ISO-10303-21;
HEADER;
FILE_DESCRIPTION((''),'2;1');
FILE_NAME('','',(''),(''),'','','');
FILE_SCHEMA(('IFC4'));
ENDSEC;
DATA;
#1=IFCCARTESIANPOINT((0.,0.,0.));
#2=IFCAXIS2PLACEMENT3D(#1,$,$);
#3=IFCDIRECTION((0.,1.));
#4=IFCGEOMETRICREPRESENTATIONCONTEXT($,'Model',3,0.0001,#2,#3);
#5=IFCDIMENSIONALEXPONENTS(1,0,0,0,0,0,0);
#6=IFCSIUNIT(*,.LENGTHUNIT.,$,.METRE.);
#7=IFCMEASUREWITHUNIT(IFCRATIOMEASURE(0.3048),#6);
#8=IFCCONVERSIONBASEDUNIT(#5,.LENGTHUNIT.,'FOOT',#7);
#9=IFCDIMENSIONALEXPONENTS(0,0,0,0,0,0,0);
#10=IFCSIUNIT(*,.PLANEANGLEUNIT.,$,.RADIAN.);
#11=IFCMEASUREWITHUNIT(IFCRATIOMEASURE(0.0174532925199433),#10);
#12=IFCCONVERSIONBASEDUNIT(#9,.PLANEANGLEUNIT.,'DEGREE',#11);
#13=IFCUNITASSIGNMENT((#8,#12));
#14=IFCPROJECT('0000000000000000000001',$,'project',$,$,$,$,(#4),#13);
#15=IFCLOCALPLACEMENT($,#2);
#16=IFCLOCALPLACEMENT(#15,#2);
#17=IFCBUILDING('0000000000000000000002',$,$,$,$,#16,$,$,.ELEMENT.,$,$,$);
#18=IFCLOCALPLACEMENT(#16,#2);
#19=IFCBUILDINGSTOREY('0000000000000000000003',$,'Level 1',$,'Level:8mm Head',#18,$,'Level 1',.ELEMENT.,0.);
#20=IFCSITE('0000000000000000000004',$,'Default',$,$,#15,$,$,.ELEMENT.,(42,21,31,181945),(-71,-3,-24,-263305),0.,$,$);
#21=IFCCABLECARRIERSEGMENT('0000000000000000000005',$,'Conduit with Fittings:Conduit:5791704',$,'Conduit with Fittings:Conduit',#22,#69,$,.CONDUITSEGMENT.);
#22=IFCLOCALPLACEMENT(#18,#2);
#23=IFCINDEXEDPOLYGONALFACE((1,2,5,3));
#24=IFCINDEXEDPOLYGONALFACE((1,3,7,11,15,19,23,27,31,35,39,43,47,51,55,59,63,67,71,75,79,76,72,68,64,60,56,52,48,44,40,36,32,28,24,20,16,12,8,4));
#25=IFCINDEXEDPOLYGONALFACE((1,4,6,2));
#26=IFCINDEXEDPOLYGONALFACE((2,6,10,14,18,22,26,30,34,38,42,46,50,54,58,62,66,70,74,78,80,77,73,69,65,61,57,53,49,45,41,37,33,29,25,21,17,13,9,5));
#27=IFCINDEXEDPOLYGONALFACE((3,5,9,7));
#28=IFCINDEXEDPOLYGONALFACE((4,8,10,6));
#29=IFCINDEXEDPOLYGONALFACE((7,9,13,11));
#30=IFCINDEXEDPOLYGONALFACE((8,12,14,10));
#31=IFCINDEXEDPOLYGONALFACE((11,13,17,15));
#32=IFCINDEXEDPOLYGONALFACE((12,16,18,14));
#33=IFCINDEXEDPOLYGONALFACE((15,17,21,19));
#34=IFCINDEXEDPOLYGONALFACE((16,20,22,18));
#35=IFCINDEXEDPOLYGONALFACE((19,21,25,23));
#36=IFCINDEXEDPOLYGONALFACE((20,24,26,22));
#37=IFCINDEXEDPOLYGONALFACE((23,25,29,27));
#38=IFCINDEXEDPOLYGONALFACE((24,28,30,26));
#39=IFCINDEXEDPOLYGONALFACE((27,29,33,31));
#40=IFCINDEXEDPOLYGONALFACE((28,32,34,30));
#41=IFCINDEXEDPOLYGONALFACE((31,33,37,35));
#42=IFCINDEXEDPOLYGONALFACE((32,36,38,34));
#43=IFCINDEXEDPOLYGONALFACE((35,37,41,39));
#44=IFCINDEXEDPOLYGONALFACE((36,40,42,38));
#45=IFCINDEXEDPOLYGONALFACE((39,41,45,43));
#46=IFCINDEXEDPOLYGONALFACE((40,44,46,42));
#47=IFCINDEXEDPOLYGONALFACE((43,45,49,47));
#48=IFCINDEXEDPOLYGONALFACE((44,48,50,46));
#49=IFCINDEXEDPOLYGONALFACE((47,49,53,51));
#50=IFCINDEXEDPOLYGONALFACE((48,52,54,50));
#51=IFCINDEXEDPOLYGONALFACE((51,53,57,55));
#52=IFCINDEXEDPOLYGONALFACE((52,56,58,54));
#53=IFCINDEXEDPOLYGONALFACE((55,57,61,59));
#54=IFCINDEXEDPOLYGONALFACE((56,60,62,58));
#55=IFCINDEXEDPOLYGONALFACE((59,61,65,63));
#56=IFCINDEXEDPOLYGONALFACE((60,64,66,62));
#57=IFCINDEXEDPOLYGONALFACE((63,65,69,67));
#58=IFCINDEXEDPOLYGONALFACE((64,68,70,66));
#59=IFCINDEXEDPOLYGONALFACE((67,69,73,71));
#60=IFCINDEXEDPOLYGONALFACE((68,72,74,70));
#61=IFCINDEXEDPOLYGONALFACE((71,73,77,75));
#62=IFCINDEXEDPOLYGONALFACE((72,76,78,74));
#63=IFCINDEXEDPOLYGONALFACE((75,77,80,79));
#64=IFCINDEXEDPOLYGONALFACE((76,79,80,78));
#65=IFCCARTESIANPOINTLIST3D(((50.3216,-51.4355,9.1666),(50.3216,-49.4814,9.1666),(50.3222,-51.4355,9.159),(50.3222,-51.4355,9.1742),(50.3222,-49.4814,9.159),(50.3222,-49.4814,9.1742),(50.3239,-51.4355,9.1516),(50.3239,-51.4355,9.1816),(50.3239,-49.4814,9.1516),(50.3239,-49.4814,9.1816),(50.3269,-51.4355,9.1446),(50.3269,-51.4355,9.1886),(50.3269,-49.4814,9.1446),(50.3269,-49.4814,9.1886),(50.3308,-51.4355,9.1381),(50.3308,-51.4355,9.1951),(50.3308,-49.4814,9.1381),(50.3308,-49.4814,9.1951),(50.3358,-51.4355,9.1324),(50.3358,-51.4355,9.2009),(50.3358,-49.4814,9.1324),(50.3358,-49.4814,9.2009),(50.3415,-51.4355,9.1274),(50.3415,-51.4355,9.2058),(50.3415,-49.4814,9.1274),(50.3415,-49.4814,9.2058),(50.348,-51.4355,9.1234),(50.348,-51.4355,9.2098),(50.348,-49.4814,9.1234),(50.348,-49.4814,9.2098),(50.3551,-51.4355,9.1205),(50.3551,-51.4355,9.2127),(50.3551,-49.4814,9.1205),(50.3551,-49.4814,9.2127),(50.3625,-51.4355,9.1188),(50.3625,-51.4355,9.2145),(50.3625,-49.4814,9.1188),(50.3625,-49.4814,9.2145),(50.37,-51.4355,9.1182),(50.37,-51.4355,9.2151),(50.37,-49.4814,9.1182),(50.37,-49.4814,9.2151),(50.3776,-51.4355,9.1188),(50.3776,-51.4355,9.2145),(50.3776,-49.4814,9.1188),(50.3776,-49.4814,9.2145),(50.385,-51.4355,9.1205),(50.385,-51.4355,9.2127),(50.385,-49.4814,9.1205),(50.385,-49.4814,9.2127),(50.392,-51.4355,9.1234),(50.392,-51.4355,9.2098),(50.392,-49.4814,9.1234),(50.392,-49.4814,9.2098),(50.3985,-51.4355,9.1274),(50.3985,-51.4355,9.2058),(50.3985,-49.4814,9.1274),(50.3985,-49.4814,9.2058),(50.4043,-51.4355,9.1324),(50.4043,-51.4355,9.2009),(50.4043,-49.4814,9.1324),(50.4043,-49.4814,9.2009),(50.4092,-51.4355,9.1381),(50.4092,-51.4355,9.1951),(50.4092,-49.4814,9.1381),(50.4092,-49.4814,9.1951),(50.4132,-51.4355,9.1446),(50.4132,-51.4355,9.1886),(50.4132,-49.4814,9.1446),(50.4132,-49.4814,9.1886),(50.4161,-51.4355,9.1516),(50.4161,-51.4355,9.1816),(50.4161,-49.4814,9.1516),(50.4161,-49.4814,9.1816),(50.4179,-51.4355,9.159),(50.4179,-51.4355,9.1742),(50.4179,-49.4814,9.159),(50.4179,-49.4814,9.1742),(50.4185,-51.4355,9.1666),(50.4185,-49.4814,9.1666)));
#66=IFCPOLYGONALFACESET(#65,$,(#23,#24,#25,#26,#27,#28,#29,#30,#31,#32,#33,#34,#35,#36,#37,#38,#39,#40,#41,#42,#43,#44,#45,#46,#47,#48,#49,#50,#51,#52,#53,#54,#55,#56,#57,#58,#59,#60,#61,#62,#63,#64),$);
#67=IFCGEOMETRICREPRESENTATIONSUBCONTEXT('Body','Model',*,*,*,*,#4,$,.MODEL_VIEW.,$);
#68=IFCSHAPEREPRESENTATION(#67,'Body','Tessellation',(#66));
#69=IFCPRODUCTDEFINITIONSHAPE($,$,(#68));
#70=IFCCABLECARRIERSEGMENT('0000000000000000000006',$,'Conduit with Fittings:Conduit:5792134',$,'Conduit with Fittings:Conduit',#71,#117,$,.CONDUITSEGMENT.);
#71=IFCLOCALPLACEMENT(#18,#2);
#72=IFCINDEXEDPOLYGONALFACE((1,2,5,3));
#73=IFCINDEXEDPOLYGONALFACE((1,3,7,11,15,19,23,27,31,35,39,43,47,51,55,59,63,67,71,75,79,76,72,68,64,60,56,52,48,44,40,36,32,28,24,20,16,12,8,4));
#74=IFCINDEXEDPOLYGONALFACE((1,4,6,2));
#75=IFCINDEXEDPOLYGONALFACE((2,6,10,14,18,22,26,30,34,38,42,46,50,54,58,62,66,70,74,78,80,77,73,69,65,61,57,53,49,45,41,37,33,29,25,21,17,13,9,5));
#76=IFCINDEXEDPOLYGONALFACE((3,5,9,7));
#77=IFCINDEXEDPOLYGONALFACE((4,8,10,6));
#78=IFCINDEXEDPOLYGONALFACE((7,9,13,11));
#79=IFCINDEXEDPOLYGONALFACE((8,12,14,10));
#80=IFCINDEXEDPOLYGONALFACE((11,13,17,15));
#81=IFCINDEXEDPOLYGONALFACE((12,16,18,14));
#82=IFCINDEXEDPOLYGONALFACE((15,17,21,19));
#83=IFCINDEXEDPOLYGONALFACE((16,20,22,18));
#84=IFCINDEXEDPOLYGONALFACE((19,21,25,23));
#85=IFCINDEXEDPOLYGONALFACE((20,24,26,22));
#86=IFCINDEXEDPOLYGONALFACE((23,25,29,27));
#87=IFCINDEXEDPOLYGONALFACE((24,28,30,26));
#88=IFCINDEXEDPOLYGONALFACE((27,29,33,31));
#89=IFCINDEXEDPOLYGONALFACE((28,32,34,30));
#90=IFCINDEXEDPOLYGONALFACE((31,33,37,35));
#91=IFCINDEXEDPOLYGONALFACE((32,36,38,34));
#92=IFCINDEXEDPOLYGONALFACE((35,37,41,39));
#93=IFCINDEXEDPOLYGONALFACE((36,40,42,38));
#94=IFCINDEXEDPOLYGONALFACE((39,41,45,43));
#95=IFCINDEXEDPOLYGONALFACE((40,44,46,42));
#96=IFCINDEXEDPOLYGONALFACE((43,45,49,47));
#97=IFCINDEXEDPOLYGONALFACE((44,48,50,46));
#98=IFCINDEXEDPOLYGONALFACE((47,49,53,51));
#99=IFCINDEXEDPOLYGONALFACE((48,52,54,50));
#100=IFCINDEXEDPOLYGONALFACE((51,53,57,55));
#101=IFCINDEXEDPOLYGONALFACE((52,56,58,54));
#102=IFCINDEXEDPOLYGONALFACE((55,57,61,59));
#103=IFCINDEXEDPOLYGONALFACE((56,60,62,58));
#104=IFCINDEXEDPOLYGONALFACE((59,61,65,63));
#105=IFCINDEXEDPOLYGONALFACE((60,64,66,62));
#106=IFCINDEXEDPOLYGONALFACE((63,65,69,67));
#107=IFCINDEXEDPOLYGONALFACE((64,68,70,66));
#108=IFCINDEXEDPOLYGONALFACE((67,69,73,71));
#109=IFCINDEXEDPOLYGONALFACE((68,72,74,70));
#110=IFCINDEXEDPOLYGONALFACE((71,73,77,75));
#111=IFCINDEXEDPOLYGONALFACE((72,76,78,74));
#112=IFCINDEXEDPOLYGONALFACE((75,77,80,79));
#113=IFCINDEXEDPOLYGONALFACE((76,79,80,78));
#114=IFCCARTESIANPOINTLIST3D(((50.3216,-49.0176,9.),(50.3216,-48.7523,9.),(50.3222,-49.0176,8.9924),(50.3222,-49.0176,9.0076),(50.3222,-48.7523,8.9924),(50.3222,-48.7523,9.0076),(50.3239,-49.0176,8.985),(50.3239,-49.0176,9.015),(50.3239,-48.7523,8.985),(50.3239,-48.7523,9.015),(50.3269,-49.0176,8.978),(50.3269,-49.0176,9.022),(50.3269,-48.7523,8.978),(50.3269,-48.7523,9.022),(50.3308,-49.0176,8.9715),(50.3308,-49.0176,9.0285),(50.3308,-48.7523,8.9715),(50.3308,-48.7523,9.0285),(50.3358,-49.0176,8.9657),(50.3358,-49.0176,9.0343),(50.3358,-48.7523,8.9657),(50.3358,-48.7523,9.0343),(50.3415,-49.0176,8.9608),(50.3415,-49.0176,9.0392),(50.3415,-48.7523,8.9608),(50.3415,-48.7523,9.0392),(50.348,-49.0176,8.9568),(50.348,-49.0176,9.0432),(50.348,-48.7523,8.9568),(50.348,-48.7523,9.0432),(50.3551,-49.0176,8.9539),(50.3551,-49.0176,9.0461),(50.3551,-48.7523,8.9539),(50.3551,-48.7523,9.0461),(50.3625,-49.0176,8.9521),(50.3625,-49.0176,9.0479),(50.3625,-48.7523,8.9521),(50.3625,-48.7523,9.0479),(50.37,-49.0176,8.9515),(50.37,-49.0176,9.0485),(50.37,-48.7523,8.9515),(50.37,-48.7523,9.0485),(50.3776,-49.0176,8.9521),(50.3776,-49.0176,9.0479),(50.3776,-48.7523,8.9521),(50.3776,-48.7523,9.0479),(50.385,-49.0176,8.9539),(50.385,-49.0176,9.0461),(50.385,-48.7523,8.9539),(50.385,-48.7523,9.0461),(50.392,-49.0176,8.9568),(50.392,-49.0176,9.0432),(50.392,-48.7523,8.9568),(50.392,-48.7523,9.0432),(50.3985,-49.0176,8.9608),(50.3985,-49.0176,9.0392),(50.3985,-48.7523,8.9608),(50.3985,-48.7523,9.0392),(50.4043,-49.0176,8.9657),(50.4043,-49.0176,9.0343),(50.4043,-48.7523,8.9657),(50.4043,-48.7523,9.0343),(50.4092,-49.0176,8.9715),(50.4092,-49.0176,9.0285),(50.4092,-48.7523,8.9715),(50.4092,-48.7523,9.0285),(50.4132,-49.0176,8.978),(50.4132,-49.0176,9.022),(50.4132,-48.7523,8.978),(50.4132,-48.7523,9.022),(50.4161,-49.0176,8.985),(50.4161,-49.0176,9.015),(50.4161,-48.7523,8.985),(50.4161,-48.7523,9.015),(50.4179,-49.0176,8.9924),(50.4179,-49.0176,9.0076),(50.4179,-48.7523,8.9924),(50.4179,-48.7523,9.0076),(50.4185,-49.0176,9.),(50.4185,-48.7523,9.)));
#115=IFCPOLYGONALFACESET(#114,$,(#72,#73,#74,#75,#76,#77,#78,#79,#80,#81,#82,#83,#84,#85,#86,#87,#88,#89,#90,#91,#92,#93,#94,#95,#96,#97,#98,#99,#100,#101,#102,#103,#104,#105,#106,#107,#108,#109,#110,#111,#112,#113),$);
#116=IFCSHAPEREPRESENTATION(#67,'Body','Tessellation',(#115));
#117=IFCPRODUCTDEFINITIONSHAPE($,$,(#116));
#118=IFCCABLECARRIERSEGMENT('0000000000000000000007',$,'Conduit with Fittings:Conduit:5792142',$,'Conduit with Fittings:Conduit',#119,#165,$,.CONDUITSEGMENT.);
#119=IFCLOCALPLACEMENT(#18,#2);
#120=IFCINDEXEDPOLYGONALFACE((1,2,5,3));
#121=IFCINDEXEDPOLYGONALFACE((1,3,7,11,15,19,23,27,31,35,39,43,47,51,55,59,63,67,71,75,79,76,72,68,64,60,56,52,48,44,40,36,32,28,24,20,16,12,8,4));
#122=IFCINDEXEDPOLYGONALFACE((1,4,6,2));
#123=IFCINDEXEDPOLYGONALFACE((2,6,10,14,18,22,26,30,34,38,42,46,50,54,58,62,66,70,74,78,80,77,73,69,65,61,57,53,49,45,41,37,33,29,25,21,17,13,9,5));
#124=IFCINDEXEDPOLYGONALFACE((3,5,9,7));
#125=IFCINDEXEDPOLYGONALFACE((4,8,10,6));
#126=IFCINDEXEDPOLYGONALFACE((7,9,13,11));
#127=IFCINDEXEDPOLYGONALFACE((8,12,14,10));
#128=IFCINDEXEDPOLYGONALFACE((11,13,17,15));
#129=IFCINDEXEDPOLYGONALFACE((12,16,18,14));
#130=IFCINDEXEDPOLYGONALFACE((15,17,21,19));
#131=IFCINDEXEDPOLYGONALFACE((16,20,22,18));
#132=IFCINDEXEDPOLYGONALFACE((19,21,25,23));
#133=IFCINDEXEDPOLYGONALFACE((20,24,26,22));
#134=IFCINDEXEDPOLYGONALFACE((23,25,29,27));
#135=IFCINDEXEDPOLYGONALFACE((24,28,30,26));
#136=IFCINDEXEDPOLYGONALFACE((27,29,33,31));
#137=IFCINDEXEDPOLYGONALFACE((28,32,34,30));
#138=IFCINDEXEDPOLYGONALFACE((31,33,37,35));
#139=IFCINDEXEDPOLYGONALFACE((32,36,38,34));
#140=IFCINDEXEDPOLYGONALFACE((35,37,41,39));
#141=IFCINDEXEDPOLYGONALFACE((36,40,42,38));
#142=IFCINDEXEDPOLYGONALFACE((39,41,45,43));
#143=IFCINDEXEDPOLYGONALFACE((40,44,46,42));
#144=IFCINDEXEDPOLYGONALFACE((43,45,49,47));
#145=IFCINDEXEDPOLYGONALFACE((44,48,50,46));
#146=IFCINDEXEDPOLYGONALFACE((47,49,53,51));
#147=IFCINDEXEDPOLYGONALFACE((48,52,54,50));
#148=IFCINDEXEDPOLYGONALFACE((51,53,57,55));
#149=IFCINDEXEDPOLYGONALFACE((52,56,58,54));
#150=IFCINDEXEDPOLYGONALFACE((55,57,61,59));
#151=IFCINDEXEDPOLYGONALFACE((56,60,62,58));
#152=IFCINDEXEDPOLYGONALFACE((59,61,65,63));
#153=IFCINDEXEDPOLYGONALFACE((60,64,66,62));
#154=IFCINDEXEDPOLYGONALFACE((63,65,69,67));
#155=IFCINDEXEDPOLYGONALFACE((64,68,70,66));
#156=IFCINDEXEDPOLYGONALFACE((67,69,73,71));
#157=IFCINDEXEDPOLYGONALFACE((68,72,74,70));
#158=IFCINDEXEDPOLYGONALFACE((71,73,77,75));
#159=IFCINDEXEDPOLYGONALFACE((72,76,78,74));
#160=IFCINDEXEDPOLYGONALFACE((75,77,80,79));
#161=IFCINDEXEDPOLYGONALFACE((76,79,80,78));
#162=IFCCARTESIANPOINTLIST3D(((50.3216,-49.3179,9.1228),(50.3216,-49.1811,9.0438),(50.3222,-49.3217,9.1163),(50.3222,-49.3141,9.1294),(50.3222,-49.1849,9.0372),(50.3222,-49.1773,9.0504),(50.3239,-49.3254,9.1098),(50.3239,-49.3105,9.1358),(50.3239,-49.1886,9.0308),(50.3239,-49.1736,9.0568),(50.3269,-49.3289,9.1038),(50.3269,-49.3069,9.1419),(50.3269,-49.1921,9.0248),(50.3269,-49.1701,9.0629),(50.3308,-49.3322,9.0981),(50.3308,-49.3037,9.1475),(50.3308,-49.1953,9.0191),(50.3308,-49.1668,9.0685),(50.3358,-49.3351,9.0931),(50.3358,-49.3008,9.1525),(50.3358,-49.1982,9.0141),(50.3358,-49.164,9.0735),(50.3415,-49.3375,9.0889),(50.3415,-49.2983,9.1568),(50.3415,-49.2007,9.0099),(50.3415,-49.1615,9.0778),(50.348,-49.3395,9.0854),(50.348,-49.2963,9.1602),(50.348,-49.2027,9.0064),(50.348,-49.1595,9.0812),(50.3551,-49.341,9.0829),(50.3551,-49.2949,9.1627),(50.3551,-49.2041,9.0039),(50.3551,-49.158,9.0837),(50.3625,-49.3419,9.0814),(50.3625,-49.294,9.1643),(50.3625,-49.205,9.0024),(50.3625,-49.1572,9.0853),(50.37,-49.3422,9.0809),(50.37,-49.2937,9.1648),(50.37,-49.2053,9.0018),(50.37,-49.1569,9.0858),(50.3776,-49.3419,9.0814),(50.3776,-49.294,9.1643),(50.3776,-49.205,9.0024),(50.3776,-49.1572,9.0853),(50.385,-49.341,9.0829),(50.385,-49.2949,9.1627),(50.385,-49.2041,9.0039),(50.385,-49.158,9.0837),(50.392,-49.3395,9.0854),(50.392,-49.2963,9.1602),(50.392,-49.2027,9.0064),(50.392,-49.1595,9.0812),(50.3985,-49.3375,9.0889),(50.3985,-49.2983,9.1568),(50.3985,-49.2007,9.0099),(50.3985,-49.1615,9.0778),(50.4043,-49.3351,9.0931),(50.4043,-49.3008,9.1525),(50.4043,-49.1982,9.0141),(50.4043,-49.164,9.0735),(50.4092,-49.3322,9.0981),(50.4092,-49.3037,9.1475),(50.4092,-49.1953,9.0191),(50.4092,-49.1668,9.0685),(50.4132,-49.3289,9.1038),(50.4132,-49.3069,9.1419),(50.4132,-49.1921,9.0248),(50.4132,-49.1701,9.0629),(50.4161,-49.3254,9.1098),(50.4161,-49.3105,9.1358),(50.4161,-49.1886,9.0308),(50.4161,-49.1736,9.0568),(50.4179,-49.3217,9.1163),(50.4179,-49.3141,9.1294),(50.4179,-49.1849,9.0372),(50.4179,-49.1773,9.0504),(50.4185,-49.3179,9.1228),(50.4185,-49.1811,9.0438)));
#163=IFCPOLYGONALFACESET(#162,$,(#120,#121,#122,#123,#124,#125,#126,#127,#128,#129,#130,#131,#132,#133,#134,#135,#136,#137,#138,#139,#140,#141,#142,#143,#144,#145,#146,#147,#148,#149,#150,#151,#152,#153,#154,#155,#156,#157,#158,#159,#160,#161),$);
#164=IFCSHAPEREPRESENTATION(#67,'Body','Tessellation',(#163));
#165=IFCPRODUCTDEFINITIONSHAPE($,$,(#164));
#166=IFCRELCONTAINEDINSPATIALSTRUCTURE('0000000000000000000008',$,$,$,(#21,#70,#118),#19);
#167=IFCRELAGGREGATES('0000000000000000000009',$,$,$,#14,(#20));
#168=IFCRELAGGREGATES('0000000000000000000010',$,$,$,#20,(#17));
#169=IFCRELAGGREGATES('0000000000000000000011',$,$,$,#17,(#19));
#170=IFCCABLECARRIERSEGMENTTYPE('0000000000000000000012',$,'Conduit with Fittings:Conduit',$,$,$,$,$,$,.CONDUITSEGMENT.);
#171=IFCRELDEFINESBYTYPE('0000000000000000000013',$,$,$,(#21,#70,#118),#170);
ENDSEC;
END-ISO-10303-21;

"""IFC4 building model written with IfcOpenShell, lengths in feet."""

from ifc_helpers import new_model, entity, si_unit, converted_unit, direction, frame, origin, place, context, subcontext, project, spatial, indexed_curve, outline, extrude, type_object, element, save


model = new_model("IFC4")

# Units and contexts
model_context = context("Model", 3, precision=0.0001, world=origin(), true_north=direction((0.0, 1.0)))
body_context = subcontext(model_context, "Body", "Model", "MODEL_VIEW")
ifc_project = project(units=[converted_unit("LENGTHUNIT", "FOOT", entity("IfcRatioMeasure", 0.3048), si_unit("LENGTHUNIT", "METRE"), dimensions=[1, 0, 0, 0, 0, 0, 0]), converted_unit("PLANEANGLEUNIT", "DEGREE", entity("IfcRatioMeasure", 0.0174532925199433), si_unit("PLANEANGLEUNIT", "RADIAN"), dimensions=[0, 0, 0, 0, 0, 0, 0])], contexts=[model_context])

# Site, building, storey
site_placement = place(None, origin())
site = spatial("IfcSite", under=ifc_project, at=site_placement, Name="Default", CompositionType="ELEMENT", RefLatitude=(42, 21, 31, 181945), RefLongitude=(-71, -3, -24, -263305), RefElevation=0.0)
building_placement = place(site_placement, origin())
building = spatial("IfcBuilding", under=site, at=building_placement, CompositionType="ELEMENT")
storey_placement = place(building_placement, origin())
storey = spatial("IfcBuildingStorey", under=building, at=storey_placement, Name="Level 1", ObjectType="Level:8mm Head", LongName="Level 1", CompositionType="ELEMENT", Elevation=0.0)

# Cable carrier segments
cable_carrier_segment_type_1 = type_object("IfcCableCarrierSegmentType", Name="Conduit with Fittings:Conduit", PredefinedType="CONDUITSEGMENT")
cable_carrier_segment_1_placement = place(storey_placement, origin())
element("IfcCableCarrierSegment", 1, at=cable_carrier_segment_1_placement, inside=storey, type_object=cable_carrier_segment_type_1, Name="Conduit with Fittings:Conduit:5791704", ObjectType="Conduit with Fittings:Conduit", PredefinedType="CONDUITSEGMENT", context=body_context, shape_type="SweptSolid", body=[
    extrude(outline(indexed_curve([(0.0485, 0.0), (0.0479, 0.0076), (0.0461, 0.015), (0.0432, 0.022), (0.0392, 0.0285), (0.0343, 0.0343), (0.0285, 0.0392), (0.022, 0.0432), (0.015, 0.0461), (0.0076, 0.0479), (0.0, 0.0485), (-0.0076, 0.0479), (-0.015, 0.0461), (-0.022, 0.0432), (-0.0285, 0.0392), (-0.0343, 0.0343), (-0.0392, 0.0285), (-0.0432, 0.022), (-0.0461, 0.015), (-0.0479, 0.0076), (-0.0485, 0.0), (-0.0479, -0.0076), (-0.0461, -0.015), (-0.0432, -0.022), (-0.0392, -0.0285), (-0.0343, -0.0343), (-0.0285, -0.0392), (-0.022, -0.0432), (-0.015, -0.0461), (-0.0076, -0.0479), (0.0, -0.0485), (0.0076, -0.0479), (0.015, -0.0461), (0.022, -0.0432), (0.0285, -0.0392), (0.0343, -0.0343), (0.0392, -0.0285), (0.0432, -0.022), (0.0461, -0.015), (0.0479, -0.0076), (0.0485, 0.0)], self_intersect=False)), frame((50.37, -51.4355, 9.1666), z_axis=(0.0, 1.0, 0.0), x_axis=(1.0, 0.0, 0.0)), (0.0, 0.0, 1.0), 1.9541),
])
cable_carrier_segment_2_placement = place(storey_placement, origin())
element("IfcCableCarrierSegment", 2, at=cable_carrier_segment_2_placement, inside=storey, type_object=cable_carrier_segment_type_1, Name="Conduit with Fittings:Conduit:5792134", ObjectType="Conduit with Fittings:Conduit", PredefinedType="CONDUITSEGMENT", context=body_context, shape_type="SweptSolid", body=[
    extrude(outline(indexed_curve([(0.0485, 0.0), (0.0479, 0.0076), (0.0461, 0.015), (0.0432, 0.022), (0.0392, 0.0285), (0.0343, 0.0343), (0.0285, 0.0392), (0.022, 0.0432), (0.015, 0.0461), (0.0076, 0.0479), (0.0, 0.0485), (-0.0076, 0.0479), (-0.015, 0.0461), (-0.022, 0.0432), (-0.0285, 0.0392), (-0.0343, 0.0343), (-0.0392, 0.0285), (-0.0432, 0.022), (-0.0461, 0.015), (-0.0479, 0.0076), (-0.0485, 0.0), (-0.0479, -0.0076), (-0.0461, -0.015), (-0.0432, -0.022), (-0.0392, -0.0285), (-0.0343, -0.0343), (-0.0285, -0.0392), (-0.022, -0.0432), (-0.015, -0.0461), (-0.0076, -0.0479), (0.0, -0.0485), (0.0076, -0.0479), (0.015, -0.0461), (0.022, -0.0432), (0.0285, -0.0392), (0.0343, -0.0343), (0.0392, -0.0285), (0.0432, -0.022), (0.0461, -0.015), (0.0479, -0.0076), (0.0485, 0.0)], self_intersect=False)), frame((50.37, -49.0176, 9.0), z_axis=(0.0, 1.0, 0.0), x_axis=(1.0, 0.0, 0.0)), (0.0, 0.0, 1.0), 0.2653),
])
cable_carrier_segment_3_placement = place(storey_placement, origin())
element("IfcCableCarrierSegment", 3, at=cable_carrier_segment_3_placement, inside=storey, type_object=cable_carrier_segment_type_1, Name="Conduit with Fittings:Conduit:5792142", ObjectType="Conduit with Fittings:Conduit", PredefinedType="CONDUITSEGMENT", context=body_context, shape_type="SweptSolid", body=[
    extrude(outline(indexed_curve([(0.0485, 0.0), (0.0479, 0.0076), (0.0461, 0.015), (0.0432, 0.022), (0.0392, 0.0285), (0.0343, 0.0343), (0.0285, 0.0392), (0.022, 0.0432), (0.015, 0.0461), (0.0076, 0.0479), (0.0, 0.0485), (-0.0076, 0.0479), (-0.015, 0.0461), (-0.022, 0.0432), (-0.0285, 0.0392), (-0.0343, 0.0343), (-0.0392, 0.0285), (-0.0432, 0.022), (-0.0461, 0.015), (-0.0479, 0.0076), (-0.0485, 0.0), (-0.0479, -0.0076), (-0.0461, -0.015), (-0.0432, -0.022), (-0.0392, -0.0285), (-0.0343, -0.0343), (-0.0285, -0.0392), (-0.022, -0.0432), (-0.015, -0.0461), (-0.0076, -0.0479), (0.0, -0.0485), (0.0076, -0.0479), (0.015, -0.0461), (0.022, -0.0432), (0.0285, -0.0392), (0.0343, -0.0343), (0.0392, -0.0285), (0.0432, -0.022), (0.0461, -0.015), (0.0479, -0.0076), (0.0485, 0.0)], self_intersect=False)), frame((50.37, -49.1811, 9.0438), z_axis=(0.0, -0.866025, 0.5), x_axis=(1.0, 0.0, 0.0)), (0.0, 0.0, 1.0), 0.158),
])

save(model, "model.ifc")
